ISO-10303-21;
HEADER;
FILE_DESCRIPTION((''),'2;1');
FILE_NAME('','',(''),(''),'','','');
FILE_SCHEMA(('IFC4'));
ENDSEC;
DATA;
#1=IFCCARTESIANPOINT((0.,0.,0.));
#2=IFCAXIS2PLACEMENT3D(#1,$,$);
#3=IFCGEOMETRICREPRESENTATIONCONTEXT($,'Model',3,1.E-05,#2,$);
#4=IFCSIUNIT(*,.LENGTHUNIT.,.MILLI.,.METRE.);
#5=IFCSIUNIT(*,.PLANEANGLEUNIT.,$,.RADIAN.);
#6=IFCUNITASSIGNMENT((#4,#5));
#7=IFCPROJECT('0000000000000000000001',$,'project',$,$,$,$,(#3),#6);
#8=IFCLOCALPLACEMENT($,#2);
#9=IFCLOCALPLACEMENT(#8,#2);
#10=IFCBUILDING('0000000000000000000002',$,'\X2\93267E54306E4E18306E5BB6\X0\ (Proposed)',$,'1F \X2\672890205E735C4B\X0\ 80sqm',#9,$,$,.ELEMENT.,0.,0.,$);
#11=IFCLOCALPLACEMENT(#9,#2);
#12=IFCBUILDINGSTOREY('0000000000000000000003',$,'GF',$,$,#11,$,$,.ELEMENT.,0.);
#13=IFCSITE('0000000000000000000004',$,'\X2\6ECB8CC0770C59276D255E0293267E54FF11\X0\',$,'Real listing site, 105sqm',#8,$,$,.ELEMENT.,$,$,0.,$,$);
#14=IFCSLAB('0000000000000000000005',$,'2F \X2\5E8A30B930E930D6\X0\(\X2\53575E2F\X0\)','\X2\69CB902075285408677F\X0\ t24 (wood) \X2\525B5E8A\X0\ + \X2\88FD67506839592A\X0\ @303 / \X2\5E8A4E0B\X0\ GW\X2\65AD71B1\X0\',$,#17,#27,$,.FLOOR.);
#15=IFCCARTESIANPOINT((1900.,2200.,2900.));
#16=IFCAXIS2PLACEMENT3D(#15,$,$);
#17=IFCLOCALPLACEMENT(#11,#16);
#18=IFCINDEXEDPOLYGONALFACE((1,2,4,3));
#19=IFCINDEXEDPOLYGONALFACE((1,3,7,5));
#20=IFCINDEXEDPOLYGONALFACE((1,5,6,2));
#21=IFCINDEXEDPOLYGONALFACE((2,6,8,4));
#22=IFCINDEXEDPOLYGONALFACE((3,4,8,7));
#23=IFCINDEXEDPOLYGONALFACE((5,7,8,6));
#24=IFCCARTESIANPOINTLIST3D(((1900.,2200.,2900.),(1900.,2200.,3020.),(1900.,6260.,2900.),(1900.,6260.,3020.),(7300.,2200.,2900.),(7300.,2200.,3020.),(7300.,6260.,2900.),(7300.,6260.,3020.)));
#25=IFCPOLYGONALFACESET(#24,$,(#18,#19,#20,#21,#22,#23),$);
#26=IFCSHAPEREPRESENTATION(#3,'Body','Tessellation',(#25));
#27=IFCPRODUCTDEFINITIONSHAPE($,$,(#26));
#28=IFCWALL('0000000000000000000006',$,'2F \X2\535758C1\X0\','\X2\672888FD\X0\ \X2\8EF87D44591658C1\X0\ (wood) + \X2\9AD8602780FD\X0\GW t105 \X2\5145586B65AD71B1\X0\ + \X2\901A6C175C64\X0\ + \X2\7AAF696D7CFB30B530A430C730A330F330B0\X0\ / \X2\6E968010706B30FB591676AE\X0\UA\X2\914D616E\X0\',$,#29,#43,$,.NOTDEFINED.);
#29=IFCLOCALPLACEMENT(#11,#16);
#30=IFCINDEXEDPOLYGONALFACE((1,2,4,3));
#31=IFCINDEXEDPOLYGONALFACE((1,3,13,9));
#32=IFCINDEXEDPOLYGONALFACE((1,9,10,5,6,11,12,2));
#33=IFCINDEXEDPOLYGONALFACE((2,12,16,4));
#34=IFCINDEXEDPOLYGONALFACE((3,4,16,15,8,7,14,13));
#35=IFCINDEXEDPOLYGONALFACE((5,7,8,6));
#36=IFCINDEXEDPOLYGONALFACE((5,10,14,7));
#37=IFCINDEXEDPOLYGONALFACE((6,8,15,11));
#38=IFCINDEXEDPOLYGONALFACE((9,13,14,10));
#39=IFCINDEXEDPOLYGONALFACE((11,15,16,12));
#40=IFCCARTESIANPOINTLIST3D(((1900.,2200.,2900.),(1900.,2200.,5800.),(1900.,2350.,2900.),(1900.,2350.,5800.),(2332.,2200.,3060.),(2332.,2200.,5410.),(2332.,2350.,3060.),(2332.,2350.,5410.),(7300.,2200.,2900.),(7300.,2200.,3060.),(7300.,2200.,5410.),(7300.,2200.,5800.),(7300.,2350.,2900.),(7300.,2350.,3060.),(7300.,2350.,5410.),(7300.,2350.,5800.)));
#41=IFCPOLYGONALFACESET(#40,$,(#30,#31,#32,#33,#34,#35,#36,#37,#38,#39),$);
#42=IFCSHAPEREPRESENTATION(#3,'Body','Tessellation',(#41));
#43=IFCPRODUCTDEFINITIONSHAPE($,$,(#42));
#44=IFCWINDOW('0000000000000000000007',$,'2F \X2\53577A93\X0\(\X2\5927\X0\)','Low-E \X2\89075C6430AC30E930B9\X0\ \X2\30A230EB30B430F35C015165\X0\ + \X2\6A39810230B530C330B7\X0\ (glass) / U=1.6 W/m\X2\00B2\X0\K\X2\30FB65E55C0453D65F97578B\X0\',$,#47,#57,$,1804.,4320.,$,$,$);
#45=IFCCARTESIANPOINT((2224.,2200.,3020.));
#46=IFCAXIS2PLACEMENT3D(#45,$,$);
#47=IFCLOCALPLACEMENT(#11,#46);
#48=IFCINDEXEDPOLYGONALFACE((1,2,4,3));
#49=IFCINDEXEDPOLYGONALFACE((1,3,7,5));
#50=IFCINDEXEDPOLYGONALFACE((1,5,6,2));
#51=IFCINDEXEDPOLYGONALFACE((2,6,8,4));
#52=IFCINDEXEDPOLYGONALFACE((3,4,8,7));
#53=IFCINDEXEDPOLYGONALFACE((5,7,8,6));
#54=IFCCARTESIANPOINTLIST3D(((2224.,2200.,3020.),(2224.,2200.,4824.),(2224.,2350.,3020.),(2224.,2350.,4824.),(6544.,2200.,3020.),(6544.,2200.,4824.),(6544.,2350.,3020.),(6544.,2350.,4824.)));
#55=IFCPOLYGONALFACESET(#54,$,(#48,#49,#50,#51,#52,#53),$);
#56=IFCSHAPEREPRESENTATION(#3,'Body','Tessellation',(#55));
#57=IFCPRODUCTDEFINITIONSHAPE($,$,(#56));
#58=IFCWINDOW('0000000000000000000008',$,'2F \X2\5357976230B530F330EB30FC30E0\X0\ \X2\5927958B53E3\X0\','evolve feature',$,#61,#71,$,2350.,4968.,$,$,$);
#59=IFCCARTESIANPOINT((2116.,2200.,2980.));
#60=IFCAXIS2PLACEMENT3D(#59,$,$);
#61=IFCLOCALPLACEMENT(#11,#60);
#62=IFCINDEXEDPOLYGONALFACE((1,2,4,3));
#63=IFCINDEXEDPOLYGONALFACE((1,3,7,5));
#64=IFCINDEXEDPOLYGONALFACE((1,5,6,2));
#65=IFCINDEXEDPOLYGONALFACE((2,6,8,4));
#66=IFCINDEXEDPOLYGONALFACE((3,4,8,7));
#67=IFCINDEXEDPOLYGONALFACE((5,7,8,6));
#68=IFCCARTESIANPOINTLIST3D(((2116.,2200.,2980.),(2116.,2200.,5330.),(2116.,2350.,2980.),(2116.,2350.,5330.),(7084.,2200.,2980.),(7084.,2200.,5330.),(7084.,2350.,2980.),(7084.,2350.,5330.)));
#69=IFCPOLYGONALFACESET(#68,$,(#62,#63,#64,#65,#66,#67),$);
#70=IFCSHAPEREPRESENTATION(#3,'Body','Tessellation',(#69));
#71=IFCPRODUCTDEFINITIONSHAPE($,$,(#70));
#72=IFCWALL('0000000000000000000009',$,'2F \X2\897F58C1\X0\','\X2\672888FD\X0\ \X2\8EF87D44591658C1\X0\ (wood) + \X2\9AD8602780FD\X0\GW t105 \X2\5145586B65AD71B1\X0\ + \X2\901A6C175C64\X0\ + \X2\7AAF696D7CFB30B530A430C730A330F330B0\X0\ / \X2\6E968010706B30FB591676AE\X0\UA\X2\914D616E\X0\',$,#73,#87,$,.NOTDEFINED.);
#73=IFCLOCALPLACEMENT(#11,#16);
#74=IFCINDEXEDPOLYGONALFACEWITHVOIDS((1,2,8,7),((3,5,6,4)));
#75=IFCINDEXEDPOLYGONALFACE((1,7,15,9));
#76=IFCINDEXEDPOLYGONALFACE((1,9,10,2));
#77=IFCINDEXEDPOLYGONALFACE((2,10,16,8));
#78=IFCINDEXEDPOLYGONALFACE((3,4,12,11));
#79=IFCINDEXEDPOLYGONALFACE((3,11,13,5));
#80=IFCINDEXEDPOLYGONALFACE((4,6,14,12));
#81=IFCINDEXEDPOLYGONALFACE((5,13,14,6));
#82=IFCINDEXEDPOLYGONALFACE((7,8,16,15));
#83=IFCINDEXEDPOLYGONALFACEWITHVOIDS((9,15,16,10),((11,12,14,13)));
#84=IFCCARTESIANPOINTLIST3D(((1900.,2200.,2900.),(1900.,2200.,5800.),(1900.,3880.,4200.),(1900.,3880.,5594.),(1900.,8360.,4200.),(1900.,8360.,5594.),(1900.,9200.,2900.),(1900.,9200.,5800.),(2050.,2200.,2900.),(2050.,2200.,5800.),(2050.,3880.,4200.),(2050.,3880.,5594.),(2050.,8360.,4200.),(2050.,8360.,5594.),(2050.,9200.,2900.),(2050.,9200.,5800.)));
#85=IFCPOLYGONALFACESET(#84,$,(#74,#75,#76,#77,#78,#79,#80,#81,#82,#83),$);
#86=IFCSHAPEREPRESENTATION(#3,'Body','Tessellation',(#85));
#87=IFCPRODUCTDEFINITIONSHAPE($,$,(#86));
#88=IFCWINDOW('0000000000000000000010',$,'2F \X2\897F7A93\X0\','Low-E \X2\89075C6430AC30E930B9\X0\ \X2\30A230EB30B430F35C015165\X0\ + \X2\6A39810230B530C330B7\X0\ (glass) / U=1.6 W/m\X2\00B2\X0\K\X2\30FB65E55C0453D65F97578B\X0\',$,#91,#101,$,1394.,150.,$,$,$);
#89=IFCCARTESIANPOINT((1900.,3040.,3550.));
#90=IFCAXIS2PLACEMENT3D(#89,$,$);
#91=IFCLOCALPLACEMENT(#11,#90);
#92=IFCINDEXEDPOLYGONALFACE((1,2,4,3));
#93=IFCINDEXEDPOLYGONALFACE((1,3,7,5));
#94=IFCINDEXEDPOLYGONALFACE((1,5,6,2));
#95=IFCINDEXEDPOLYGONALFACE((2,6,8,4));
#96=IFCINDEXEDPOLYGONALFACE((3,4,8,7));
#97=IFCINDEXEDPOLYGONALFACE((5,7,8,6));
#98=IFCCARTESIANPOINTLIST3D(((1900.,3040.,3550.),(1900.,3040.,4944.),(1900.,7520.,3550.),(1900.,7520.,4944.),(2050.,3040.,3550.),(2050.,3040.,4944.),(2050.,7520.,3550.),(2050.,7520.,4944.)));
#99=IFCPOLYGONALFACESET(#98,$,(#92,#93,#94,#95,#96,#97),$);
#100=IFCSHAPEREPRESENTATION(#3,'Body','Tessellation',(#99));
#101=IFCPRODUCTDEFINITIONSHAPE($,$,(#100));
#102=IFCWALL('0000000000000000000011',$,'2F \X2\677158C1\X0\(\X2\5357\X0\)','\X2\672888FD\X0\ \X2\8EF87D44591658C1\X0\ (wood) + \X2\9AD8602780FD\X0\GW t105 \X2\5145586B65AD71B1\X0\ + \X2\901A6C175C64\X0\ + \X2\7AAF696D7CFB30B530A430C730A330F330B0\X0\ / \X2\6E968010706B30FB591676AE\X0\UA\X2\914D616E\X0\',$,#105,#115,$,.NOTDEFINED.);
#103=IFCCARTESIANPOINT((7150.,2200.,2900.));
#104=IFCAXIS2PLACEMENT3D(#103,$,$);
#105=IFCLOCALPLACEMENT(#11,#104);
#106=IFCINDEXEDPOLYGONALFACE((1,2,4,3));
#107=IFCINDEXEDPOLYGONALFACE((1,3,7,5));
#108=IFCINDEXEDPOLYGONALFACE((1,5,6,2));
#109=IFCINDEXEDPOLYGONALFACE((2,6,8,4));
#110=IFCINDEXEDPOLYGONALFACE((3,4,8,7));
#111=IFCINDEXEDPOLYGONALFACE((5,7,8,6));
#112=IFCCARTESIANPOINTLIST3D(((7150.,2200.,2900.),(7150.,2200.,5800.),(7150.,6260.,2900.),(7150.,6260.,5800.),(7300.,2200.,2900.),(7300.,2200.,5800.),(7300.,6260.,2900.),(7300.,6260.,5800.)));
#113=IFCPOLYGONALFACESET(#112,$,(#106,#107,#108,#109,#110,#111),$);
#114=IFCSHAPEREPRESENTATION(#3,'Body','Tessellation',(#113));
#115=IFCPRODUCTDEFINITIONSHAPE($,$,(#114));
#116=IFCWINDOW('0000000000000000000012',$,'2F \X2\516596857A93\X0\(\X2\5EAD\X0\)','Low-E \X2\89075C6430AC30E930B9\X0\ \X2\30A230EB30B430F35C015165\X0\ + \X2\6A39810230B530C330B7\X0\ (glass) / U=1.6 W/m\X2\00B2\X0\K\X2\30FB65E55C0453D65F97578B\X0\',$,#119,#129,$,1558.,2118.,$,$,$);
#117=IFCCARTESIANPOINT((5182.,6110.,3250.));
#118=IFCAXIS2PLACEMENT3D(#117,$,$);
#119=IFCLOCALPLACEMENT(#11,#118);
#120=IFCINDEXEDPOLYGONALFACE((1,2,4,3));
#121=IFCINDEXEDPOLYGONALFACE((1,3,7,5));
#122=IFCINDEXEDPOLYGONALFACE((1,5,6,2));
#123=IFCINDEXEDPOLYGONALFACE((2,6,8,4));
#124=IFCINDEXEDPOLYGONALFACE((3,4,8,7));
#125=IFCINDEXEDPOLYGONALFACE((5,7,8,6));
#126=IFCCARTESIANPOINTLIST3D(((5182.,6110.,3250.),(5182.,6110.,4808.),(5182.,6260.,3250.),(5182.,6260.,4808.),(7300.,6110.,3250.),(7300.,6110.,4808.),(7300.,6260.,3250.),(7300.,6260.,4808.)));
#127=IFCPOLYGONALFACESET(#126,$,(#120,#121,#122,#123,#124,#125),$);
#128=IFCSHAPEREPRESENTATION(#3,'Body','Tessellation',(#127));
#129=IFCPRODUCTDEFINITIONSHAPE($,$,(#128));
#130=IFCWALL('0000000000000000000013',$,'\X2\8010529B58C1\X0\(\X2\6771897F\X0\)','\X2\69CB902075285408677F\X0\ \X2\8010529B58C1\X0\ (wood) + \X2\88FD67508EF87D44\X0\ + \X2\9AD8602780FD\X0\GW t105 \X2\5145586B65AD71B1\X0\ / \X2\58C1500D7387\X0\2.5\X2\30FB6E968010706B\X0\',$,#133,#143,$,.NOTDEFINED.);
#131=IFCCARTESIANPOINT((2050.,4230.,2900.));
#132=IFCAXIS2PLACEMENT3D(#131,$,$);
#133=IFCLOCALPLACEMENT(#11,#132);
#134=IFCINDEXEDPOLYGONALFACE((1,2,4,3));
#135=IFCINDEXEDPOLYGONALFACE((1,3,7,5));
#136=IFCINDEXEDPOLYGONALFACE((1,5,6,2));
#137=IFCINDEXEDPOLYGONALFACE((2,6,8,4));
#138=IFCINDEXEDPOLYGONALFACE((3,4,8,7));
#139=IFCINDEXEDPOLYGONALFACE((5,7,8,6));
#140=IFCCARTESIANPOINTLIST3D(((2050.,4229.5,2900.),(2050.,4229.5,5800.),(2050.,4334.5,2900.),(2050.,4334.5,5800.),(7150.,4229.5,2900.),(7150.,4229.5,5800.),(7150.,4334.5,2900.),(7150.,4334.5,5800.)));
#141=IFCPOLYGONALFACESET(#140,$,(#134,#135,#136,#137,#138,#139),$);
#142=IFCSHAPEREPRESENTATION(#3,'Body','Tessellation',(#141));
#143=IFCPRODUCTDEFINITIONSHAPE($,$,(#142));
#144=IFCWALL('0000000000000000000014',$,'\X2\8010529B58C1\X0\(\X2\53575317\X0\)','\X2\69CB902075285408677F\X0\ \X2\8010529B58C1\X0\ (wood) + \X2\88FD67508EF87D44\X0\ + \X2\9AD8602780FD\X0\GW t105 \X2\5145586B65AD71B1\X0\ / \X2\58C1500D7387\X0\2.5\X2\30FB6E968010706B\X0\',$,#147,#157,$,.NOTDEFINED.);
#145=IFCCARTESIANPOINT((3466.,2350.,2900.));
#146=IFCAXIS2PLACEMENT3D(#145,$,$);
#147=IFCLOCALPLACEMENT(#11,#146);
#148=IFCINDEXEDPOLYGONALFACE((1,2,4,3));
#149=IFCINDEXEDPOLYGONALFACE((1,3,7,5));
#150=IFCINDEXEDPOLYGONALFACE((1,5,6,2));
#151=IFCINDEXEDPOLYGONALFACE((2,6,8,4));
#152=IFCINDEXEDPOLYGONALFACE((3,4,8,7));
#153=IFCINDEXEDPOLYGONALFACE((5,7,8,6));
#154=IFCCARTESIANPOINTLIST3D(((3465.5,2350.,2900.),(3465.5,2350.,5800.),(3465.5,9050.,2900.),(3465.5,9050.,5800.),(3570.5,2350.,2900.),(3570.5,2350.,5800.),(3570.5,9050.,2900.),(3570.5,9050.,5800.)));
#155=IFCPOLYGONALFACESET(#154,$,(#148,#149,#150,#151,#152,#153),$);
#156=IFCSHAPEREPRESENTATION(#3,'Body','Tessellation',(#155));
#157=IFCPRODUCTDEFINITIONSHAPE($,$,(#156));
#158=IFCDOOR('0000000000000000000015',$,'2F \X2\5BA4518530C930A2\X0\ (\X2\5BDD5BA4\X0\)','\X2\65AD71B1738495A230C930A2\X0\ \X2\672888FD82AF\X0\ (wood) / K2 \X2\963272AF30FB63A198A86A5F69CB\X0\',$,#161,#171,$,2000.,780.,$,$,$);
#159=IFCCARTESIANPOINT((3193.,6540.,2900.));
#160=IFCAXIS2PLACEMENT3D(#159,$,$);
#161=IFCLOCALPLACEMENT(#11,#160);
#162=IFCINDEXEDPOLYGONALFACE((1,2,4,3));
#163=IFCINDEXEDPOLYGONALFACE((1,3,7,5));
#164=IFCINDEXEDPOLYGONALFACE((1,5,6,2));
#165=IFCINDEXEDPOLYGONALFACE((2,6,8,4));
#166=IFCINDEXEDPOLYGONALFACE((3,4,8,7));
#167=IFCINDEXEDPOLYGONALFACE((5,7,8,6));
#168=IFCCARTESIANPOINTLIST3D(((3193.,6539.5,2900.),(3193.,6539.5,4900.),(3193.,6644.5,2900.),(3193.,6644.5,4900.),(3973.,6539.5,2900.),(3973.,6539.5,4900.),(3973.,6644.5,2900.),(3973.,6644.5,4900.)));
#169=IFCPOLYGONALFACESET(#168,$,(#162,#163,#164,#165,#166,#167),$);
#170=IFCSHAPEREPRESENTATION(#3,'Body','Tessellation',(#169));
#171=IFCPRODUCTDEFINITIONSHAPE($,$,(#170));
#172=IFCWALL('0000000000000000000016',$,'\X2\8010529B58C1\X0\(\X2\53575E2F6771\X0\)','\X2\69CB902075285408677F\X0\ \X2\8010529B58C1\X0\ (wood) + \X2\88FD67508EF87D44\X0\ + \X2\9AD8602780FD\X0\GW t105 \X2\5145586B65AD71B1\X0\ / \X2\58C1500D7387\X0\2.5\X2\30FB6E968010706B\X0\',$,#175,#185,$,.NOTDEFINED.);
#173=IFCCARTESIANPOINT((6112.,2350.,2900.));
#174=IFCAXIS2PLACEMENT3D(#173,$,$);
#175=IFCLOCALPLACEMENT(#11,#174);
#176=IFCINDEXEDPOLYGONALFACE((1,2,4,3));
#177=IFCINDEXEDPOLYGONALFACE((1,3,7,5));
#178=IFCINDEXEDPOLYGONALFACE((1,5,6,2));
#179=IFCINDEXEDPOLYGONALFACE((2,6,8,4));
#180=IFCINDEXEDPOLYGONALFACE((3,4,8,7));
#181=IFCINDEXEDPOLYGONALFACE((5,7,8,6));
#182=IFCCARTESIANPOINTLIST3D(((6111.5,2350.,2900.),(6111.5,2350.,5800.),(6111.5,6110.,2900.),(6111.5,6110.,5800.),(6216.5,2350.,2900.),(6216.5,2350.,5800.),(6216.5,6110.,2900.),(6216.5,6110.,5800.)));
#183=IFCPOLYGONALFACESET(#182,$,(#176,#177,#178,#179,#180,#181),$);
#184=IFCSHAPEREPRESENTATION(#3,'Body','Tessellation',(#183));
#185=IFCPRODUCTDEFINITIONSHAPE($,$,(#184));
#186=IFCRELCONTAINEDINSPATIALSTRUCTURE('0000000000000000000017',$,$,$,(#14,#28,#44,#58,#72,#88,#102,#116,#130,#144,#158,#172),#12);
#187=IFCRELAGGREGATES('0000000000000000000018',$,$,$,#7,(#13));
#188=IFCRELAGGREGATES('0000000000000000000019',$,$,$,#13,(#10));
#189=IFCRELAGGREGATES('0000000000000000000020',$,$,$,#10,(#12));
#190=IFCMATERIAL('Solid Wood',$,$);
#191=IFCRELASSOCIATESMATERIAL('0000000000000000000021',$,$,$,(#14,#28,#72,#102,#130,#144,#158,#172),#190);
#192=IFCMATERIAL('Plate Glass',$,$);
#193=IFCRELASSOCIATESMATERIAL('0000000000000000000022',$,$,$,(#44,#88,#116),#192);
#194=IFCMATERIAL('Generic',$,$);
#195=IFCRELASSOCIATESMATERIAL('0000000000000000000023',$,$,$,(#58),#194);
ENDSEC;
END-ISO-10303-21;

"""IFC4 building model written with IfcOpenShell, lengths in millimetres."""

from ifc_helpers import new_model, si_unit, frame, frame_2d, origin, place, context, project, spatial, rectangle, extrude, material, element, fill, save


model = new_model("IFC4")

# Units and contexts
model_context = context("Model", 3, precision=1e-05, world=origin())
ifc_project = project(units=[si_unit("LENGTHUNIT", "METRE", prefix="MILLI"), si_unit("PLANEANGLEUNIT", "RADIAN")], contexts=[model_context])

# Site, building, storey
site_placement = place(None, origin())
site = spatial("IfcSite", under=ifc_project, at=site_placement, Name="滋賀県大津市錦織１", ObjectType="Real listing site, 105sqm", CompositionType="ELEMENT", RefElevation=0.0)
building_placement = place(site_placement, origin())
building = spatial("IfcBuilding", under=site, at=building_placement, Name="錦織の丘の家 (Proposed)", ObjectType="1F 木造平屋 80sqm", CompositionType="ELEMENT", ElevationOfRefHeight=0.0, ElevationOfTerrain=0.0)
storey_placement = place(building_placement, origin())
storey = spatial("IfcBuildingStorey", under=building, at=storey_placement, Name="GF", CompositionType="ELEMENT", Elevation=0.0)

# Slab
ifc_material_1 = material(Name="Solid Wood")
slab_placement = place(storey_placement, frame((1900.0, 2200.0, 2900.0)))
element("IfcSlab", 1, at=slab_placement, inside=storey, material=ifc_material_1, Name="2F 床スラブ(南帯)", Description="構造用合板 t24 (wood) 剛床 + 製材根太 @303 / 床下 GW断熱", PredefinedType="FLOOR", context=model_context, shape_type="SweptSolid", body=[
    extrude(rectangle(XDim=5400.0, YDim=4060.0, at=frame_2d((2700.0, 2030.0))), frame((1900.0, 2200.0, 2900.0)), (0.0, 0.0, 1.0), 120.0),
])

# Wall, openings, windows
wall_1_placement = place(storey_placement, frame((1900.0, 2200.0, 2900.0)))
wall_1 = element("IfcWall", 2, at=wall_1_placement, inside=storey, material=ifc_material_1, Name="2F 南壁", Description="木製 軸組外壁 (wood) + 高性能GW t105 充填断熱 + 通気層 + 窯業系サイディング / 準耐火・外皮UA配慮", PredefinedType="NOTDEFINED", context=model_context, shape_type="SweptSolid", body=[
    extrude(rectangle(XDim=5400.0, YDim=150.0, at=frame_2d((2700.0, 75.0))), frame((1900.0, 2200.0, 2900.0)), (0.0, 0.0, 1.0), 2900.0),
])
opening_1_placement = place(storey_placement, frame((2224.0, 2200.0, 3020.0)))
opening_1 = element("IfcOpeningElement", 3, at=opening_1_placement, cuts=wall_1, PredefinedType="NOTDEFINED", context=model_context, shape_type="SweptSolid", body=[
    extrude(rectangle(XDim=4320.0, YDim=150.0, at=frame_2d((2160.0, 75.0))), frame((2224.0, 2200.0, 3020.0)), (0.0, 0.0, 1.0), 1804.0),
])
opening_2_placement = place(storey_placement, frame((2116.0, 2200.0, 2980.0)))
opening_2 = element("IfcOpeningElement", 4, at=opening_2_placement, cuts=wall_1, PredefinedType="NOTDEFINED", context=model_context, shape_type="SweptSolid", body=[
    extrude(rectangle(XDim=4968.0, YDim=150.0, at=frame_2d((2484.0, 75.0))), frame((2116.0, 2200.0, 2980.0)), (0.0, 0.0, 1.0), 2350.0),
])
ifc_material_2 = material(Name="Plate Glass")
window_1_placement = place(storey_placement, frame((2224.0, 2200.0, 3020.0)))
window_1 = element("IfcWindow", 5, at=window_1_placement, inside=storey, material=ifc_material_2, Name="2F 南窓(大)", Description="Low-E 複層ガラス アルゴン封入 + 樹脂サッシ (glass) / U=1.6 W/m²K・日射取得型", OverallHeight=1804.0, OverallWidth=4320.0, context=model_context, shape_type="SweptSolid", body=[
    extrude(rectangle(XDim=4320.0, YDim=150.0, at=frame_2d((2160.0, 75.0))), frame((2224.0, 2200.0, 3020.0)), (0.0, 0.0, 1.0), 1804.0),
])
fill(opening_1, window_1)
ifc_material_3 = material(Name="Generic")
window_2_placement = place(storey_placement, frame((2116.0, 2200.0, 2980.0)))
window_2 = element("IfcWindow", 6, at=window_2_placement, inside=storey, material=ifc_material_3, Name="2F 南面サンルーム 大開口", Description="evolve feature", OverallHeight=2350.0, OverallWidth=4968.0, context=model_context, shape_type="SweptSolid", body=[
    extrude(rectangle(XDim=4968.0, YDim=150.0, at=frame_2d((2484.0, 75.0))), frame((2116.0, 2200.0, 2980.0)), (0.0, 0.0, 1.0), 2350.0),
])
fill(opening_2, window_2)

# Walls, openings, windows
wall_2_placement = place(storey_placement, frame((1900.0, 2200.0, 2900.0)))
wall_2 = element("IfcWall", 7, at=wall_2_placement, inside=storey, material=ifc_material_1, Name="2F 西壁", Description="木製 軸組外壁 (wood) + 高性能GW t105 充填断熱 + 通気層 + 窯業系サイディング / 準耐火・外皮UA配慮", PredefinedType="NOTDEFINED", context=model_context, shape_type="SweptSolid", body=[
    extrude(rectangle(XDim=150.0, YDim=7000.0, at=frame_2d((75.0, 3500.0))), frame((1900.0, 2200.0, 2900.0)), (0.0, 0.0, 1.0), 2900.0),
])
opening_3_placement = place(storey_placement, frame((1900.0, 3040.0, 3550.0)))
opening_3 = element("IfcOpeningElement", 8, at=opening_3_placement, cuts=wall_2, PredefinedType="NOTDEFINED", context=model_context, shape_type="SweptSolid", body=[
    extrude(rectangle(XDim=150.0, YDim=4480.0, at=frame_2d((75.0, 2240.0))), frame((1900.0, 3040.0, 3550.0)), (0.0, 0.0, 1.0), 1394.0),
])
window_3_placement = place(storey_placement, frame((1900.0, 3040.0, 3550.0)))
window_3 = element("IfcWindow", 9, at=window_3_placement, inside=storey, material=ifc_material_2, Name="2F 西窓", Description="Low-E 複層ガラス アルゴン封入 + 樹脂サッシ (glass) / U=1.6 W/m²K・日射取得型", OverallHeight=1394.0, OverallWidth=150.0, context=model_context, shape_type="SweptSolid", body=[
    extrude(rectangle(XDim=150.0, YDim=4480.0, at=frame_2d((75.0, 2240.0))), frame((1900.0, 3040.0, 3550.0)), (0.0, 0.0, 1.0), 1394.0),
])
fill(opening_3, window_3)
wall_3_placement = place(storey_placement, frame((7150.0, 2200.0, 2900.0)))
wall_3 = element("IfcWall", 10, at=wall_3_placement, inside=storey, material=ifc_material_1, Name="2F 東壁(南)", Description="木製 軸組外壁 (wood) + 高性能GW t105 充填断熱 + 通気層 + 窯業系サイディング / 準耐火・外皮UA配慮", PredefinedType="NOTDEFINED", context=model_context, shape_type="SweptSolid", body=[
    extrude(rectangle(XDim=150.0, YDim=4060.0, at=frame_2d((75.0, 2030.0))), frame((7150.0, 2200.0, 2900.0)), (0.0, 0.0, 1.0), 2900.0),
])
opening_4_placement = place(storey_placement, frame((5182.0, 6110.0, 3250.0)))
opening_4 = element("IfcOpeningElement", 11, at=opening_4_placement, cuts=wall_3, PredefinedType="NOTDEFINED", context=model_context, shape_type="SweptSolid", body=[
    extrude(rectangle(XDim=2118.0, YDim=150.0, at=frame_2d((1059.0, 75.0))), frame((5182.0, 6110.0, 3250.0)), (0.0, 0.0, 1.0), 1558.0),
])
window_4_placement = place(storey_placement, frame((5182.0, 6110.0, 3250.0)))
window_4 = element("IfcWindow", 12, at=window_4_placement, inside=storey, material=ifc_material_2, Name="2F 入隅窓(庭)", Description="Low-E 複層ガラス アルゴン封入 + 樹脂サッシ (glass) / U=1.6 W/m²K・日射取得型", OverallHeight=1558.0, OverallWidth=2118.0, context=model_context, shape_type="SweptSolid", body=[
    extrude(rectangle(XDim=2118.0, YDim=150.0, at=frame_2d((1059.0, 75.0))), frame((5182.0, 6110.0, 3250.0)), (0.0, 0.0, 1.0), 1558.0),
])
fill(opening_4, window_4)

# Wall
wall_4_placement = place(storey_placement, frame((2050.0, 4230.0, 2900.0)))
element("IfcWall", 13, at=wall_4_placement, inside=storey, material=ifc_material_1, Name="耐力壁(東西)", Description="構造用合板 耐力壁 (wood) + 製材軸組 + 高性能GW t105 充填断熱 / 壁倍率2.5・準耐火", PredefinedType="NOTDEFINED", context=model_context, shape_type="SweptSolid", body=[
    extrude(rectangle(XDim=5100.0, YDim=105.0, at=frame_2d((2550.0, 52.0))), frame((2050.0, 4230.0, 2900.0)), (0.0, 0.0, 1.0), 2900.0),
])

# Wall, opening, door
wall_5_placement = place(storey_placement, frame((3466.0, 2350.0, 2900.0)))
wall_5 = element("IfcWall", 14, at=wall_5_placement, inside=storey, material=ifc_material_1, Name="耐力壁(南北)", Description="構造用合板 耐力壁 (wood) + 製材軸組 + 高性能GW t105 充填断熱 / 壁倍率2.5・準耐火", PredefinedType="NOTDEFINED", context=model_context, shape_type="SweptSolid", body=[
    extrude(rectangle(XDim=105.0, YDim=6700.0, at=frame_2d((52.0, 3350.0))), frame((3466.0, 2350.0, 2900.0)), (0.0, 0.0, 1.0), 2900.0),
])
opening_5_placement = place(storey_placement, frame((3193.0, 6540.0, 2900.0)))
opening_5 = element("IfcOpeningElement", 15, at=opening_5_placement, cuts=wall_5, PredefinedType="NOTDEFINED", context=model_context, shape_type="SweptSolid", body=[
    extrude(rectangle(XDim=780.0, YDim=105.0, at=frame_2d((390.0, 52.0))), frame((3193.0, 6540.0, 2900.0)), (0.0, 0.0, 1.0), 2000.0),
])
door_placement = place(storey_placement, frame((3193.0, 6540.0, 2900.0)))
door = element("IfcDoor", 16, at=door_placement, inside=storey, material=ifc_material_1, Name="2F 室内ドア (寝室)", Description="断熱玄関ドア 木製芯 (wood) / K2 防犯・採風機構", OverallHeight=2000.0, OverallWidth=780.0, context=model_context, shape_type="SweptSolid", body=[
    extrude(rectangle(XDim=780.0, YDim=105.0, at=frame_2d((390.0, 52.0))), frame((3193.0, 6540.0, 2900.0)), (0.0, 0.0, 1.0), 2000.0),
])
fill(opening_5, door)

# Wall
wall_6_placement = place(storey_placement, frame((6112.0, 2350.0, 2900.0)))
element("IfcWall", 17, at=wall_6_placement, inside=storey, material=ifc_material_1, Name="耐力壁(南帯東)", Description="構造用合板 耐力壁 (wood) + 製材軸組 + 高性能GW t105 充填断熱 / 壁倍率2.5・準耐火", PredefinedType="NOTDEFINED", context=model_context, shape_type="SweptSolid", body=[
    extrude(rectangle(XDim=105.0, YDim=3760.0, at=frame_2d((52.0, 1880.0))), frame((6112.0, 2350.0, 2900.0)), (0.0, 0.0, 1.0), 2900.0),
])

save(model, "model.ifc")
